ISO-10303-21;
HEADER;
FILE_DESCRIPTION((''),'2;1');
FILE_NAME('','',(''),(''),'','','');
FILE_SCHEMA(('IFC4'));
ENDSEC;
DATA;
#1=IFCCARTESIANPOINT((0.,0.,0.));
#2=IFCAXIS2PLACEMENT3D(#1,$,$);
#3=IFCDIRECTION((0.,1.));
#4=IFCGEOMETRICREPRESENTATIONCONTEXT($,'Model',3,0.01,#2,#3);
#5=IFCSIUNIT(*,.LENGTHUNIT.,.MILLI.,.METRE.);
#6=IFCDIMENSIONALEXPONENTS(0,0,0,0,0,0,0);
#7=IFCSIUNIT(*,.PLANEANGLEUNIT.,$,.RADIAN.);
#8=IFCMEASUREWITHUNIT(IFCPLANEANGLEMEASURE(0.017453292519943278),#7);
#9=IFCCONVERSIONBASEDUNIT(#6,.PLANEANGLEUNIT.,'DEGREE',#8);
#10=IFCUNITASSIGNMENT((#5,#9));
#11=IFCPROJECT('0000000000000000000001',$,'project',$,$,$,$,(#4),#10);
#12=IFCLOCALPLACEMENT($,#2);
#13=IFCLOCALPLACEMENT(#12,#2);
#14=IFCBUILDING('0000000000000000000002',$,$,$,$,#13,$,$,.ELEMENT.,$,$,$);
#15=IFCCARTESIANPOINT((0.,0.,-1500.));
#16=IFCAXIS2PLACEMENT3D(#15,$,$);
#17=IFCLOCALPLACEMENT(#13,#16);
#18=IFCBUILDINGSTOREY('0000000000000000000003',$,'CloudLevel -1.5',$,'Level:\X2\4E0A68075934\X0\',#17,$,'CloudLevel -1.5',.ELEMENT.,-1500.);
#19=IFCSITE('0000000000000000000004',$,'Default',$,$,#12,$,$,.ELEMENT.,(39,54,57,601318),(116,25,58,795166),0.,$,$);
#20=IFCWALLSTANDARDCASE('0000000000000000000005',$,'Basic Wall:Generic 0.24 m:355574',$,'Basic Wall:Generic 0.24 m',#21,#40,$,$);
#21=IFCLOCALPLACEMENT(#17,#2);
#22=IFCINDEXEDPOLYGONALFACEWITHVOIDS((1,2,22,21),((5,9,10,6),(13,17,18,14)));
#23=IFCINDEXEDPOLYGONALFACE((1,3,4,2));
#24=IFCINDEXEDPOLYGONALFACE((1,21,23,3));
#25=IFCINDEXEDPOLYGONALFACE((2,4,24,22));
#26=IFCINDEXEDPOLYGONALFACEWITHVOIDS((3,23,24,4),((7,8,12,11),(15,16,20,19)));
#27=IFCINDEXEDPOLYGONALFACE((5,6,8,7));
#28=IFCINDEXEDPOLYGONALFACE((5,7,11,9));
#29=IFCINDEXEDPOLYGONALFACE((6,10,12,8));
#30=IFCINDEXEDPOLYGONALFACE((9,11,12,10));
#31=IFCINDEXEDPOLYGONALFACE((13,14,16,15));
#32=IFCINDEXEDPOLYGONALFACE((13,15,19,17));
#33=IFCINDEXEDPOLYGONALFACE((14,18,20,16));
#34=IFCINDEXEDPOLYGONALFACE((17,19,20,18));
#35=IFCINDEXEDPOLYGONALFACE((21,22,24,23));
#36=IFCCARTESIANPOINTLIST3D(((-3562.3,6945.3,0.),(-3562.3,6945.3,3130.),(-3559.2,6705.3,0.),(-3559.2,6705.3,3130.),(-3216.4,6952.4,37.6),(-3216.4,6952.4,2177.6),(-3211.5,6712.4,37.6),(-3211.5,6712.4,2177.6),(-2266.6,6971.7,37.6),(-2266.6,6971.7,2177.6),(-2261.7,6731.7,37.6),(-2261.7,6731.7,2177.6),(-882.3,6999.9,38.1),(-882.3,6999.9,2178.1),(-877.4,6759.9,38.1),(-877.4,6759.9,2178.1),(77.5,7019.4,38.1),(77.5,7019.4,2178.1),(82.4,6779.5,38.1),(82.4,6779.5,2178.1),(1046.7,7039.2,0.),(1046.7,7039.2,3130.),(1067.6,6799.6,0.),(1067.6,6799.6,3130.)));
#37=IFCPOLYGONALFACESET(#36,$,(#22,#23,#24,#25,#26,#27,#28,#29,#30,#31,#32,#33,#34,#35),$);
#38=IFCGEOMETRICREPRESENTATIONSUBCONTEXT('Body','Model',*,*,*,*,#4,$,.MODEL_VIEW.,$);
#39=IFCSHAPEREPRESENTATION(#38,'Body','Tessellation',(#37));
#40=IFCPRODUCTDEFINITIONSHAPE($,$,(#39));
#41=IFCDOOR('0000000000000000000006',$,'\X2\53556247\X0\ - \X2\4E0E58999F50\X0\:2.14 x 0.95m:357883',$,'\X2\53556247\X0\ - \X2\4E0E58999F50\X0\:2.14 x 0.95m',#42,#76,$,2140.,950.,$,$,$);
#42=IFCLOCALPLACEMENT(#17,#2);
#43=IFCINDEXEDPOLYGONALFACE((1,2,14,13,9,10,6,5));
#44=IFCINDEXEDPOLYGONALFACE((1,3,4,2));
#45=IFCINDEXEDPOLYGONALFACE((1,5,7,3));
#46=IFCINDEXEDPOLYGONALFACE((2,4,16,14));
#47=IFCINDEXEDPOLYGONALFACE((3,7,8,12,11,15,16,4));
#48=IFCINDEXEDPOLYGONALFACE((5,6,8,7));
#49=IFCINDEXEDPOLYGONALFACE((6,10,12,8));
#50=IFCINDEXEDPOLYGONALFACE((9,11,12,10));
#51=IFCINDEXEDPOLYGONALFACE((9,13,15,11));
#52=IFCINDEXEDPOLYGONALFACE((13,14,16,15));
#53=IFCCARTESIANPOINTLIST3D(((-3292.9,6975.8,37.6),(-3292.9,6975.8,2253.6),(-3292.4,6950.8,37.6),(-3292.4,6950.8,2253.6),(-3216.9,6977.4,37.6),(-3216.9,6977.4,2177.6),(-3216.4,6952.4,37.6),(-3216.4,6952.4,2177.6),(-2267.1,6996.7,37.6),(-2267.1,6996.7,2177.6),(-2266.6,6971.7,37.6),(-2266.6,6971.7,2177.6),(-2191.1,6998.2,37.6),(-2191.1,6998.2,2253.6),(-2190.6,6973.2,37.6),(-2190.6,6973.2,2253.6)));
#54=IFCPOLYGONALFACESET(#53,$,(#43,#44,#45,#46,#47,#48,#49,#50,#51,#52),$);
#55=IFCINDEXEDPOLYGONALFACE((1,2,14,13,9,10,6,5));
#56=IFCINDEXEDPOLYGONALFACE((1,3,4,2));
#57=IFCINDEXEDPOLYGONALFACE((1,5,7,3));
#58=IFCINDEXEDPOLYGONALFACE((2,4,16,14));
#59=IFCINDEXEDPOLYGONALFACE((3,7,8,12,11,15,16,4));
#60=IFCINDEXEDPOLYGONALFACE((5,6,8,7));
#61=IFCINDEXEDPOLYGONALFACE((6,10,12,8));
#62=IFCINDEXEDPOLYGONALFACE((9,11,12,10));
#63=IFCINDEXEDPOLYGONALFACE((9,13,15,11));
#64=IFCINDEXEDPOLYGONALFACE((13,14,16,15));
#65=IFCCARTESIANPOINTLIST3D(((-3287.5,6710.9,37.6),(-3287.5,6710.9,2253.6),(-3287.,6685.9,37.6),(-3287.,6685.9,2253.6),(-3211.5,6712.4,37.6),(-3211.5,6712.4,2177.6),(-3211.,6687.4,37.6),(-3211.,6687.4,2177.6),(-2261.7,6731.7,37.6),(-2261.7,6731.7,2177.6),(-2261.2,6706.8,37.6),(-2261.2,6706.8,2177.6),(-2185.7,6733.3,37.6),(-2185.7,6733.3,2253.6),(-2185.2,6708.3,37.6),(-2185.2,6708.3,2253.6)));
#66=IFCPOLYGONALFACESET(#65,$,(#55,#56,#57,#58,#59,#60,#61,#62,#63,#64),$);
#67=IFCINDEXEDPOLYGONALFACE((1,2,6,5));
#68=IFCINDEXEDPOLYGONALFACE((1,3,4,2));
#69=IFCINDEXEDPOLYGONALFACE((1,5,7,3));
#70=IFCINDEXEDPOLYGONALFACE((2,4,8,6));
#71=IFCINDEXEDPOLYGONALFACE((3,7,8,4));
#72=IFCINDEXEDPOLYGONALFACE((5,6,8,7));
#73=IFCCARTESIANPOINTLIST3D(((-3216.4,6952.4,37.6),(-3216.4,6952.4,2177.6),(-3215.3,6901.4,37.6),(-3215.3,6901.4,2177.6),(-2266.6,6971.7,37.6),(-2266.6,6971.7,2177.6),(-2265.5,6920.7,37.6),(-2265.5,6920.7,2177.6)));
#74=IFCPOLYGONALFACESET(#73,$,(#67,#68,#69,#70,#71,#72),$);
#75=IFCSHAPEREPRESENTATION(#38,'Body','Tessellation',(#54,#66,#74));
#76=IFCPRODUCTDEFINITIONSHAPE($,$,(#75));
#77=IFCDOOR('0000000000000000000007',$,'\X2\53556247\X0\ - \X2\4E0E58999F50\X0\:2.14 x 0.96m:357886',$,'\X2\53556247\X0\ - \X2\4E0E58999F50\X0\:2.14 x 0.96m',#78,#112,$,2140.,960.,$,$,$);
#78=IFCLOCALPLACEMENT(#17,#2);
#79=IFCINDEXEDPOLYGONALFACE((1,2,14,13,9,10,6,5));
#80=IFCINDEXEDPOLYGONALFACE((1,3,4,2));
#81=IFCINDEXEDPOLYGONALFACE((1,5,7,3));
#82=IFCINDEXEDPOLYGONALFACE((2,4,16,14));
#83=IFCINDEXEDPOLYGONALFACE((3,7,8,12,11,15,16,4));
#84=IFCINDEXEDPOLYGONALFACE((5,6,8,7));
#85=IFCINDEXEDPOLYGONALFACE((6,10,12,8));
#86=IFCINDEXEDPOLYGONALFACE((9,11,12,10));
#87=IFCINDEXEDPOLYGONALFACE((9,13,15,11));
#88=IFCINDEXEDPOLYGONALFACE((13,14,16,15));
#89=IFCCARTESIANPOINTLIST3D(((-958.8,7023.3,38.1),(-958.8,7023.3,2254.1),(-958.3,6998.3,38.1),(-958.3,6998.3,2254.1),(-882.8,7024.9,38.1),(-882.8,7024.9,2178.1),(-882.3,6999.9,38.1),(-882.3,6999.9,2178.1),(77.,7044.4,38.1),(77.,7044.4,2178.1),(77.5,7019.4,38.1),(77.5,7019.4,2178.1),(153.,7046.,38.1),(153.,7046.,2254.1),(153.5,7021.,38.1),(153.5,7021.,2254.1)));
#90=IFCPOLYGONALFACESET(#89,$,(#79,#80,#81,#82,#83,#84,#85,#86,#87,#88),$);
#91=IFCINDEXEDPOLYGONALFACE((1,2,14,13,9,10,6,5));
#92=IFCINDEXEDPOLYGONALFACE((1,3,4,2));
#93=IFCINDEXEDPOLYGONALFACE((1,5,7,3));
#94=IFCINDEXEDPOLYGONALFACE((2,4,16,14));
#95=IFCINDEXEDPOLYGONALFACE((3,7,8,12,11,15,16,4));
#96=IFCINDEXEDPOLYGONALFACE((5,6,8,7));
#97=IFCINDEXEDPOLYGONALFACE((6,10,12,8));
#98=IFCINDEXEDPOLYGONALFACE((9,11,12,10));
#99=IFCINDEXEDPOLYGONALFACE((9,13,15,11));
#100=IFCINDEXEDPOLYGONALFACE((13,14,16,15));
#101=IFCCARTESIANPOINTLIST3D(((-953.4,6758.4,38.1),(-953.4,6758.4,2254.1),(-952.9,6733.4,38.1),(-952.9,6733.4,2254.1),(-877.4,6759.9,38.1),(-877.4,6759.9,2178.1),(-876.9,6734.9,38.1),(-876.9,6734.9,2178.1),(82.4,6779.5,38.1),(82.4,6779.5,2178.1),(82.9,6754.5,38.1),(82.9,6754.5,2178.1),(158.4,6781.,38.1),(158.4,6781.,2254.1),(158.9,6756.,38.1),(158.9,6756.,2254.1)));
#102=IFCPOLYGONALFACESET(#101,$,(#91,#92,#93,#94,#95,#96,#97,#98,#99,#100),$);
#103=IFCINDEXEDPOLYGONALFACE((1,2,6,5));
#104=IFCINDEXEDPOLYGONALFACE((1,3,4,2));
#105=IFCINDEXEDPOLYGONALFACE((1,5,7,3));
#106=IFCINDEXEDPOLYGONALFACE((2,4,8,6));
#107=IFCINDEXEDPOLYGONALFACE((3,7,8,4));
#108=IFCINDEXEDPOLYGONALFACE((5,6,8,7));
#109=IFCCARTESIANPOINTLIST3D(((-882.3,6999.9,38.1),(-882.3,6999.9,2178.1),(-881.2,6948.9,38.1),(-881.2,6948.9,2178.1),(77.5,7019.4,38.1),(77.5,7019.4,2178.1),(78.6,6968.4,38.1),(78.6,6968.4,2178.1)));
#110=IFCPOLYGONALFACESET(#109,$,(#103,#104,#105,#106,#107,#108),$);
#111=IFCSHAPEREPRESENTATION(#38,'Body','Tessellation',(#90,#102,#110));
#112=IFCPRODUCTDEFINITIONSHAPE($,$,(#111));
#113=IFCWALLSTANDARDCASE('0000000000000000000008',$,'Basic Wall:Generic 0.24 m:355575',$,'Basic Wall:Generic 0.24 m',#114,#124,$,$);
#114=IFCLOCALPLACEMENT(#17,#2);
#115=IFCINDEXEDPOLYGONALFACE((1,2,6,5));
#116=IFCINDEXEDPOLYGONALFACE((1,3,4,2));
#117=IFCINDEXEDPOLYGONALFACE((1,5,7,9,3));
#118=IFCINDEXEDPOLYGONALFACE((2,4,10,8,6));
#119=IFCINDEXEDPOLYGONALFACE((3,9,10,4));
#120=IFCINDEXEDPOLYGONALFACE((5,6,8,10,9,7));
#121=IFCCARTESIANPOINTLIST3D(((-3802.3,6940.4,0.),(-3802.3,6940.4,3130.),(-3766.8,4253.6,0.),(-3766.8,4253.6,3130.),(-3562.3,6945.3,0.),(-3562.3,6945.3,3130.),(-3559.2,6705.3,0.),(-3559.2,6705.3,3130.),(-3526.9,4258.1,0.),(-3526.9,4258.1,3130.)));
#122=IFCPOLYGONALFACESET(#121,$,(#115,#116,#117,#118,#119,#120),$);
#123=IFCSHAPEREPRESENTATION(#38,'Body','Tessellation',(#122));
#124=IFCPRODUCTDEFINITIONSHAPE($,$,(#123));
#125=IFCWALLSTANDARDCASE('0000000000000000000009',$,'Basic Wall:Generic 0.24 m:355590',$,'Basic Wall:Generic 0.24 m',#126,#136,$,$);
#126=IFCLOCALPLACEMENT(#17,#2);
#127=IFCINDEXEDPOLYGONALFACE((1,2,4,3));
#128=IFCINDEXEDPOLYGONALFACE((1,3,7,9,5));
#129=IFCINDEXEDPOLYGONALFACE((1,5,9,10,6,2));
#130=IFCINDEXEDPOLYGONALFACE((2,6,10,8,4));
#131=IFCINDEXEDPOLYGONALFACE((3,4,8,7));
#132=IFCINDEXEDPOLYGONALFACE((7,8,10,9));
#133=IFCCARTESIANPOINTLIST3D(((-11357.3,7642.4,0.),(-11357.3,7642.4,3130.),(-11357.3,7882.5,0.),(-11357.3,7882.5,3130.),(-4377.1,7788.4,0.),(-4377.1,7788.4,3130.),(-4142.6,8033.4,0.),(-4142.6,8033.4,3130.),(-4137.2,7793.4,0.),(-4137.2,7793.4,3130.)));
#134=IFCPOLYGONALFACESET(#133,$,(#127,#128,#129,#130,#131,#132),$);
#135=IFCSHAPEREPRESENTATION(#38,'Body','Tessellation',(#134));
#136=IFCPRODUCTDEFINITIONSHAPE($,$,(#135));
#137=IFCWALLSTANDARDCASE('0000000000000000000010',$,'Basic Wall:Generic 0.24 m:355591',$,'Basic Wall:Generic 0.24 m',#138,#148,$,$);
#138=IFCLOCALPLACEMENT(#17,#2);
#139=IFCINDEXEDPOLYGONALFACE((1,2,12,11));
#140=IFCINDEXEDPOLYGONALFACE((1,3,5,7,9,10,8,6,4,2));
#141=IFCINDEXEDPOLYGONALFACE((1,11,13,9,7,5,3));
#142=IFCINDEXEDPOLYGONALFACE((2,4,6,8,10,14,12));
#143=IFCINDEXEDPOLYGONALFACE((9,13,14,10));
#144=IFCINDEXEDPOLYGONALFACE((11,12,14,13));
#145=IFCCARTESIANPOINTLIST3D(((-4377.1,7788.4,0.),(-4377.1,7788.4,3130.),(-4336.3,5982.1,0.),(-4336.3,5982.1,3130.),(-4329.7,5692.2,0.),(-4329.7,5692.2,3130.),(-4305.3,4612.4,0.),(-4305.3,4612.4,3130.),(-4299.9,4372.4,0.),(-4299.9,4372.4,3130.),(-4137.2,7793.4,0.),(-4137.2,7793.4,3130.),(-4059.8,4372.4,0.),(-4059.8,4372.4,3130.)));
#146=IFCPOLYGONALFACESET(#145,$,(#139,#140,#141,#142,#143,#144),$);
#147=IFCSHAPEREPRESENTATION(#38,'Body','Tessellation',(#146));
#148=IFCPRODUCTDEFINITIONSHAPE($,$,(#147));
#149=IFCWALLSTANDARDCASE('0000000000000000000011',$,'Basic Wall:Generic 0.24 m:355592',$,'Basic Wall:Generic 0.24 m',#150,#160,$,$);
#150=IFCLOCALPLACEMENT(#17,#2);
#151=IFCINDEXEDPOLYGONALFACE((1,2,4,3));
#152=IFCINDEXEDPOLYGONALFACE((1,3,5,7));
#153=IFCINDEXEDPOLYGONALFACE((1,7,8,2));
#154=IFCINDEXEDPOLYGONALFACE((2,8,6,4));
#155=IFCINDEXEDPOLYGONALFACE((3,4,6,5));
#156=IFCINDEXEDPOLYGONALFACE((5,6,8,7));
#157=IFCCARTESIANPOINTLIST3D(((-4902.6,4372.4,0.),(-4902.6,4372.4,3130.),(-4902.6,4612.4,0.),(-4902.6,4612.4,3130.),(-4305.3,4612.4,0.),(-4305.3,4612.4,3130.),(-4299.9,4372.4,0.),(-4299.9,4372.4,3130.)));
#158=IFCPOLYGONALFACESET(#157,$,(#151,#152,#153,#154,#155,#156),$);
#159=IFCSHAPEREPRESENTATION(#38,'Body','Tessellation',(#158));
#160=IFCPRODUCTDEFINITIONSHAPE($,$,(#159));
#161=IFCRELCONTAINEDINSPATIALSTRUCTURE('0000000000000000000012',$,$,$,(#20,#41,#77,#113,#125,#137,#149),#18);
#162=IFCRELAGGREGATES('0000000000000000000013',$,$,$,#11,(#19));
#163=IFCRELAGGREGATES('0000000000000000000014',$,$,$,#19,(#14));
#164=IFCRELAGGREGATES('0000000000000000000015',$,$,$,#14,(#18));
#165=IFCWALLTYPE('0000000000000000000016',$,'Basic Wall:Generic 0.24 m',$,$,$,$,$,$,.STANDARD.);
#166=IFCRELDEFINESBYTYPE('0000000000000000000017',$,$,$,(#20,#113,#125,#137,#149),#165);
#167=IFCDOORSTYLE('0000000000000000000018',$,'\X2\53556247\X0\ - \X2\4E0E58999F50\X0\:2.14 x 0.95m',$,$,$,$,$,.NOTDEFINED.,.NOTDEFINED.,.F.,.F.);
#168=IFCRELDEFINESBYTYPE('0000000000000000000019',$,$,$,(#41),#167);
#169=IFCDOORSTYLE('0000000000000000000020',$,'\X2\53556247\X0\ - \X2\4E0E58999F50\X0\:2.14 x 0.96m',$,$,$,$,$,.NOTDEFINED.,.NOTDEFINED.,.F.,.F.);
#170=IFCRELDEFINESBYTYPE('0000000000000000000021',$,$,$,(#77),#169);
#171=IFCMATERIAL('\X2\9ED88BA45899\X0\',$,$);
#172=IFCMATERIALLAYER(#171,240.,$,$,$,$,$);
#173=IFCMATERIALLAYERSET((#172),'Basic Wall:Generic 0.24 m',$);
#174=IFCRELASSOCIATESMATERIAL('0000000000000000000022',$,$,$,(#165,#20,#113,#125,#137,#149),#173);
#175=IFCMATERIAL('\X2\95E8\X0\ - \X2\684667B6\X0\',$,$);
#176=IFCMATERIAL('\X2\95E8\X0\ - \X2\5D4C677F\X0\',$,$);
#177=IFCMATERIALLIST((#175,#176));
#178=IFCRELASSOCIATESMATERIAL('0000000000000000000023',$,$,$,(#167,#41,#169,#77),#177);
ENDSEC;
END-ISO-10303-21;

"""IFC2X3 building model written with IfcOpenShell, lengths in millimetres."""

from ifc_helpers import new_model, entity, si_unit, converted_unit, direction, frame, frame_2d, origin, place, context, subcontext, project, spatial, polyline, rectangle, outline, extrude, source, transform, mapped, material, material_list, layer, layer_set, layer_usage, type_object, type_shapes, element, fill, save


model = new_model("IFC2X3")

# Units and contexts
model_context = context("Model", 3, precision=0.01, world=origin(), true_north=direction((0.0, 1.0)))
body_context = subcontext(model_context, "Body", "Model", "MODEL_VIEW")
ifc_project = project(units=[si_unit("LENGTHUNIT", "METRE", prefix="MILLI"), converted_unit("PLANEANGLEUNIT", "DEGREE", entity("IfcPlaneAngleMeasure", 0.017453292519943278), si_unit("PLANEANGLEUNIT", "RADIAN"), dimensions=[0, 0, 0, 0, 0, 0, 0])], contexts=[model_context])

# Site, building, storey
site_placement = place(None, origin())
site = spatial("IfcSite", under=ifc_project, at=site_placement, Name="Default", CompositionType="ELEMENT", RefLatitude=(39, 54, 57, 601318), RefLongitude=(116, 25, 58, 795166), RefElevation=0.0)
building_placement = place(site_placement, origin())
building = spatial("IfcBuilding", under=site, at=building_placement, CompositionType="ELEMENT")
storey_placement = place(building_placement, frame((0.0, 0.0, -1500.0)))
storey = spatial("IfcBuildingStorey", under=building, at=storey_placement, Name="CloudLevel -1.5", ObjectType="Level:上标头", LongName="CloudLevel -1.5", CompositionType="ELEMENT", Elevation=-1500.0)

# Wall, openings, doors
ifc_material_1 = material(Name="默认墙")
ifc_layer_1 = layer(ifc_material_1, 240.0)
ifc_layer_set_1 = layer_set([ifc_layer_1], Name="Basic Wall:Generic 0.24 m")
ifc_layer_usage_1 = layer_usage(ifc_layer_set_1, "AXIS2", "NEGATIVE", 120.0)
wall_type_1 = type_object("IfcWallType", Name="Basic Wall:Generic 0.24 m", PredefinedType="STANDARD", material=ifc_layer_set_1)
wall_1_placement = place(storey_placement, frame((-3561.6, 6825.3, 0.0), z_axis=(0.0, 0.0, 1.0), x_axis=(0.999793, 0.020361, 0.0)))
wall_1 = element("IfcWallStandardCase", 1, at=wall_1_placement, inside=storey, type_object=wall_type_1, material=ifc_layer_usage_1, Name="Basic Wall:Generic 0.24 m:355574", ObjectType="Basic Wall:Generic 0.24 m", context=body_context, shape_type="SweptSolid", body=[
    extrude(outline(polyline([(4627.7, -120.0), (4611.7, 120.0), (1.7, 120.0), (0.0, -120.0), (4627.7, -120.0)])), origin(), (0.0, 0.0, 1.0), 3130.0),
])
opening_1_placement = place(wall_1_placement, frame((347.7, -120.0, 37.6)))
opening_1 = element("IfcOpeningElement", 2, at=opening_1_placement, cuts=wall_1, ObjectType="Opening", context=body_context, shape_type="SweptSolid", body=[
    extrude(rectangle(XDim=950.0, YDim=2140.0, at=frame_2d((1070.0, 475.0), x_axis=(0.0, 1.0))), frame((0.0, 0.0, 0.0), z_axis=(0.0, 1.0, 0.0), x_axis=(0.0, 0.0, 1.0)), (0.0, 0.0, 1.0), 240.0),
])
opening_2_placement = place(wall_1_placement, frame((2682.3, -120.0, 38.1)))
opening_2 = element("IfcOpeningElement", 3, at=opening_2_placement, cuts=wall_1, ObjectType="Opening", context=body_context, shape_type="SweptSolid", body=[
    extrude(rectangle(XDim=960.0, YDim=2140.0, at=frame_2d((1070.0, 480.0), x_axis=(0.0, 1.0))), frame((0.0, 0.0, 0.0), z_axis=(0.0, 1.0, 0.0), x_axis=(0.0, 0.0, 1.0)), (0.0, 0.0, 1.0), 240.0),
])
ifc_material_2 = material(Name="门 - 框架")
ifc_material_3 = material(Name="门 - 嵌板")
ifc_material_list_1 = material_list([ifc_material_2, ifc_material_3])
door_style_1 = type_object("IfcDoorStyle", Name="单扇 - 与墙齐:2.14 x 0.95m", ConstructionType="NOTDEFINED", OperationType="NOTDEFINED", ParameterTakesPrecedence=False, Sizeable=False, material=ifc_material_list_1)
shared_shape_1 = source(origin(), body_context, "Body", "SweptSolid", [
    extrude(outline(polyline([(-551.0, -1127.0), (551.0, -1127.0), (551.0, 1089.0), (475.0, 1089.0), (475.0, -1051.0), (-475.0, -1051.0), (-475.0, 1089.0), (-551.0, 1089.0), (-551.0, -1127.0)])), frame((475.0, 240.0, 1089.0), z_axis=(0.0, 1.0, 0.0), x_axis=(1.0, 0.0, 0.0)), (0.0, 0.0, 1.0), 25.0),
    extrude(outline(polyline([(-1127.0, -551.0), (1089.0, -551.0), (1089.0, -475.0), (-1051.0, -475.0), (-1051.0, 475.0), (1089.0, 475.0), (1089.0, 551.0), (-1127.0, 551.0), (-1127.0, -551.0)])), frame((475.0, -25.0, 1089.0), z_axis=(0.0, 1.0, 0.0), x_axis=(0.0, 0.0, -1.0)), (0.0, 0.0, 1.0), 25.0),
    extrude(rectangle(XDim=51.0, YDim=950.0, at=frame_2d((0.0, 0.0), x_axis=(1.0, 0.0))), frame((475.0, 214.5, 0.0), z_axis=(0.0, 0.0, 1.0), x_axis=(0.0, 1.0, 0.0)), (0.0, 0.0, 1.0), 2140.0),
])
type_shapes(door_style_1, [shared_shape_1])
door_1_placement = place(opening_1_placement, frame((0.0, 0.0, 0.0)))
door_1 = element("IfcDoor", 4, at=door_1_placement, inside=storey, type_object=door_style_1, material=ifc_material_list_1, Name="单扇 - 与墙齐:2.14 x 0.95m:357883", ObjectType="单扇 - 与墙齐:2.14 x 0.95m", OverallHeight=2140.0, OverallWidth=950.0, context=body_context, shape_type="MappedRepresentation", body=[
    mapped(shared_shape_1, transform((0.0, 0.0, 0.0), scale=1.0)),
])
fill(opening_1, door_1)
door_style_2 = type_object("IfcDoorStyle", Name="单扇 - 与墙齐:2.14 x 0.96m", ConstructionType="NOTDEFINED", OperationType="NOTDEFINED", ParameterTakesPrecedence=False, Sizeable=False, material=ifc_material_list_1)
shared_shape_2 = source(origin(), body_context, "Body", "SweptSolid", [
    extrude(outline(polyline([(-556.0, -1127.0), (556.0, -1127.0), (556.0, 1089.0), (480.0, 1089.0), (480.0, -1051.0), (-480.0, -1051.0), (-480.0, 1089.0), (-556.0, 1089.0), (-556.0, -1127.0)])), frame((480.0, 240.0, 1089.0), z_axis=(0.0, 1.0, 0.0), x_axis=(1.0, 0.0, 0.0)), (0.0, 0.0, 1.0), 25.0),
    extrude(outline(polyline([(-1127.0, -556.0), (1089.0, -556.0), (1089.0, -480.0), (-1051.0, -480.0), (-1051.0, 480.0), (1089.0, 480.0), (1089.0, 556.0), (-1127.0, 556.0), (-1127.0, -556.0)])), frame((480.0, -25.0, 1089.0), z_axis=(0.0, 1.0, 0.0), x_axis=(0.0, 0.0, -1.0)), (0.0, 0.0, 1.0), 25.0),
    extrude(rectangle(XDim=51.0, YDim=960.0, at=frame_2d((0.0, 0.0), x_axis=(1.0, 0.0))), frame((480.0, 214.5, 0.0), z_axis=(0.0, 0.0, 1.0), x_axis=(0.0, 1.0, 0.0)), (0.0, 0.0, 1.0), 2140.0),
])
type_shapes(door_style_2, [shared_shape_2])
door_2_placement = place(opening_2_placement, frame((0.0, 0.0, 0.0)))
door_2 = element("IfcDoor", 5, at=door_2_placement, inside=storey, type_object=door_style_2, material=ifc_material_list_1, Name="单扇 - 与墙齐:2.14 x 0.96m:357886", ObjectType="单扇 - 与墙齐:2.14 x 0.96m", OverallHeight=2140.0, OverallWidth=960.0, context=body_context, shape_type="MappedRepresentation", body=[
    mapped(shared_shape_2, transform((0.0, 0.0, 0.0), scale=1.0)),
])
fill(opening_2, door_2)

# Walls
wall_2_placement = place(storey_placement, frame((-3646.8, 4255.2, 0.0), z_axis=(0.0, 0.0, 1.0), x_axis=(-0.013193, 0.999913, 0.0)))
element("IfcWallStandardCase", 6, at=wall_2_placement, inside=storey, type_object=wall_type_1, material=ifc_layer_usage_1, Name="Basic Wall:Generic 0.24 m:355575", ObjectType="Basic Wall:Generic 0.24 m", context=body_context, shape_type="SweptSolid", body=[
    extrude(outline(polyline([(2688.8, -120.0), (2687.0, 120.0), (0.0, 120.0), (1.3, -120.0), (2448.8, -120.0), (2688.8, -120.0)])), origin(), (0.0, 0.0, 1.0), 3130.0),
])
wall_3_placement = place(storey_placement, frame((-11359.8, 7762.4, 0.0), z_axis=(0.0, 0.0, 1.0), x_axis=(0.999781, 0.020913, 0.0)))
element("IfcWallStandardCase", 7, at=wall_3_placement, inside=storey, type_object=wall_type_1, material=ifc_layer_usage_1, Name="Basic Wall:Generic 0.24 m:355590", ObjectType="Basic Wall:Generic 0.24 m", context=body_context, shape_type="SweptSolid", body=[
    extrude(outline(polyline([(7221.6, -120.0), (7221.2, 120.0), (5.0, 120.0), (0.0, -120.0), (6981.6, -120.0), (7221.6, -120.0)])), origin(), (0.0, 0.0, 1.0), 3130.0),
])
wall_4_placement = place(storey_placement, frame((-4257.2, 7791.1, 0.0), z_axis=(0.0, 0.0, 1.0), x_axis=(0.022613, -0.999744, 0.0)))
element("IfcWallStandardCase", 8, at=wall_4_placement, inside=storey, type_object=wall_type_1, material=ifc_layer_usage_1, Name="Basic Wall:Generic 0.24 m:355591", ObjectType="Basic Wall:Generic 0.24 m", context=body_context, shape_type="SweptSolid", body=[
    extrude(outline(polyline([(3416.9, -120.0), (3422.3, 120.0), (0.4, 120.0), (0.0, -120.0), (1806.7, -120.0), (2096.7, -120.0), (3176.8, -120.0), (3416.9, -120.0)])), origin(), (0.0, 0.0, 1.0), 3130.0),
])
wall_5_placement = place(storey_placement, frame((-4299.9, 4492.4, 0.0), z_axis=(0.0, 0.0, 1.0), x_axis=(-1.0, 0.0, 0.0)))
element("IfcWallStandardCase", 9, at=wall_5_placement, inside=storey, type_object=wall_type_1, material=ifc_layer_usage_1, Name="Basic Wall:Generic 0.24 m:355592", ObjectType="Basic Wall:Generic 0.24 m", context=body_context, shape_type="SweptSolid", body=[
    extrude(outline(polyline([(602.7, -120.0), (602.7, 120.0), (0.0, 120.0), (5.4, -120.0), (602.7, -120.0)])), origin(), (0.0, 0.0, 1.0), 3130.0),
])

save(model, "model.ifc")
